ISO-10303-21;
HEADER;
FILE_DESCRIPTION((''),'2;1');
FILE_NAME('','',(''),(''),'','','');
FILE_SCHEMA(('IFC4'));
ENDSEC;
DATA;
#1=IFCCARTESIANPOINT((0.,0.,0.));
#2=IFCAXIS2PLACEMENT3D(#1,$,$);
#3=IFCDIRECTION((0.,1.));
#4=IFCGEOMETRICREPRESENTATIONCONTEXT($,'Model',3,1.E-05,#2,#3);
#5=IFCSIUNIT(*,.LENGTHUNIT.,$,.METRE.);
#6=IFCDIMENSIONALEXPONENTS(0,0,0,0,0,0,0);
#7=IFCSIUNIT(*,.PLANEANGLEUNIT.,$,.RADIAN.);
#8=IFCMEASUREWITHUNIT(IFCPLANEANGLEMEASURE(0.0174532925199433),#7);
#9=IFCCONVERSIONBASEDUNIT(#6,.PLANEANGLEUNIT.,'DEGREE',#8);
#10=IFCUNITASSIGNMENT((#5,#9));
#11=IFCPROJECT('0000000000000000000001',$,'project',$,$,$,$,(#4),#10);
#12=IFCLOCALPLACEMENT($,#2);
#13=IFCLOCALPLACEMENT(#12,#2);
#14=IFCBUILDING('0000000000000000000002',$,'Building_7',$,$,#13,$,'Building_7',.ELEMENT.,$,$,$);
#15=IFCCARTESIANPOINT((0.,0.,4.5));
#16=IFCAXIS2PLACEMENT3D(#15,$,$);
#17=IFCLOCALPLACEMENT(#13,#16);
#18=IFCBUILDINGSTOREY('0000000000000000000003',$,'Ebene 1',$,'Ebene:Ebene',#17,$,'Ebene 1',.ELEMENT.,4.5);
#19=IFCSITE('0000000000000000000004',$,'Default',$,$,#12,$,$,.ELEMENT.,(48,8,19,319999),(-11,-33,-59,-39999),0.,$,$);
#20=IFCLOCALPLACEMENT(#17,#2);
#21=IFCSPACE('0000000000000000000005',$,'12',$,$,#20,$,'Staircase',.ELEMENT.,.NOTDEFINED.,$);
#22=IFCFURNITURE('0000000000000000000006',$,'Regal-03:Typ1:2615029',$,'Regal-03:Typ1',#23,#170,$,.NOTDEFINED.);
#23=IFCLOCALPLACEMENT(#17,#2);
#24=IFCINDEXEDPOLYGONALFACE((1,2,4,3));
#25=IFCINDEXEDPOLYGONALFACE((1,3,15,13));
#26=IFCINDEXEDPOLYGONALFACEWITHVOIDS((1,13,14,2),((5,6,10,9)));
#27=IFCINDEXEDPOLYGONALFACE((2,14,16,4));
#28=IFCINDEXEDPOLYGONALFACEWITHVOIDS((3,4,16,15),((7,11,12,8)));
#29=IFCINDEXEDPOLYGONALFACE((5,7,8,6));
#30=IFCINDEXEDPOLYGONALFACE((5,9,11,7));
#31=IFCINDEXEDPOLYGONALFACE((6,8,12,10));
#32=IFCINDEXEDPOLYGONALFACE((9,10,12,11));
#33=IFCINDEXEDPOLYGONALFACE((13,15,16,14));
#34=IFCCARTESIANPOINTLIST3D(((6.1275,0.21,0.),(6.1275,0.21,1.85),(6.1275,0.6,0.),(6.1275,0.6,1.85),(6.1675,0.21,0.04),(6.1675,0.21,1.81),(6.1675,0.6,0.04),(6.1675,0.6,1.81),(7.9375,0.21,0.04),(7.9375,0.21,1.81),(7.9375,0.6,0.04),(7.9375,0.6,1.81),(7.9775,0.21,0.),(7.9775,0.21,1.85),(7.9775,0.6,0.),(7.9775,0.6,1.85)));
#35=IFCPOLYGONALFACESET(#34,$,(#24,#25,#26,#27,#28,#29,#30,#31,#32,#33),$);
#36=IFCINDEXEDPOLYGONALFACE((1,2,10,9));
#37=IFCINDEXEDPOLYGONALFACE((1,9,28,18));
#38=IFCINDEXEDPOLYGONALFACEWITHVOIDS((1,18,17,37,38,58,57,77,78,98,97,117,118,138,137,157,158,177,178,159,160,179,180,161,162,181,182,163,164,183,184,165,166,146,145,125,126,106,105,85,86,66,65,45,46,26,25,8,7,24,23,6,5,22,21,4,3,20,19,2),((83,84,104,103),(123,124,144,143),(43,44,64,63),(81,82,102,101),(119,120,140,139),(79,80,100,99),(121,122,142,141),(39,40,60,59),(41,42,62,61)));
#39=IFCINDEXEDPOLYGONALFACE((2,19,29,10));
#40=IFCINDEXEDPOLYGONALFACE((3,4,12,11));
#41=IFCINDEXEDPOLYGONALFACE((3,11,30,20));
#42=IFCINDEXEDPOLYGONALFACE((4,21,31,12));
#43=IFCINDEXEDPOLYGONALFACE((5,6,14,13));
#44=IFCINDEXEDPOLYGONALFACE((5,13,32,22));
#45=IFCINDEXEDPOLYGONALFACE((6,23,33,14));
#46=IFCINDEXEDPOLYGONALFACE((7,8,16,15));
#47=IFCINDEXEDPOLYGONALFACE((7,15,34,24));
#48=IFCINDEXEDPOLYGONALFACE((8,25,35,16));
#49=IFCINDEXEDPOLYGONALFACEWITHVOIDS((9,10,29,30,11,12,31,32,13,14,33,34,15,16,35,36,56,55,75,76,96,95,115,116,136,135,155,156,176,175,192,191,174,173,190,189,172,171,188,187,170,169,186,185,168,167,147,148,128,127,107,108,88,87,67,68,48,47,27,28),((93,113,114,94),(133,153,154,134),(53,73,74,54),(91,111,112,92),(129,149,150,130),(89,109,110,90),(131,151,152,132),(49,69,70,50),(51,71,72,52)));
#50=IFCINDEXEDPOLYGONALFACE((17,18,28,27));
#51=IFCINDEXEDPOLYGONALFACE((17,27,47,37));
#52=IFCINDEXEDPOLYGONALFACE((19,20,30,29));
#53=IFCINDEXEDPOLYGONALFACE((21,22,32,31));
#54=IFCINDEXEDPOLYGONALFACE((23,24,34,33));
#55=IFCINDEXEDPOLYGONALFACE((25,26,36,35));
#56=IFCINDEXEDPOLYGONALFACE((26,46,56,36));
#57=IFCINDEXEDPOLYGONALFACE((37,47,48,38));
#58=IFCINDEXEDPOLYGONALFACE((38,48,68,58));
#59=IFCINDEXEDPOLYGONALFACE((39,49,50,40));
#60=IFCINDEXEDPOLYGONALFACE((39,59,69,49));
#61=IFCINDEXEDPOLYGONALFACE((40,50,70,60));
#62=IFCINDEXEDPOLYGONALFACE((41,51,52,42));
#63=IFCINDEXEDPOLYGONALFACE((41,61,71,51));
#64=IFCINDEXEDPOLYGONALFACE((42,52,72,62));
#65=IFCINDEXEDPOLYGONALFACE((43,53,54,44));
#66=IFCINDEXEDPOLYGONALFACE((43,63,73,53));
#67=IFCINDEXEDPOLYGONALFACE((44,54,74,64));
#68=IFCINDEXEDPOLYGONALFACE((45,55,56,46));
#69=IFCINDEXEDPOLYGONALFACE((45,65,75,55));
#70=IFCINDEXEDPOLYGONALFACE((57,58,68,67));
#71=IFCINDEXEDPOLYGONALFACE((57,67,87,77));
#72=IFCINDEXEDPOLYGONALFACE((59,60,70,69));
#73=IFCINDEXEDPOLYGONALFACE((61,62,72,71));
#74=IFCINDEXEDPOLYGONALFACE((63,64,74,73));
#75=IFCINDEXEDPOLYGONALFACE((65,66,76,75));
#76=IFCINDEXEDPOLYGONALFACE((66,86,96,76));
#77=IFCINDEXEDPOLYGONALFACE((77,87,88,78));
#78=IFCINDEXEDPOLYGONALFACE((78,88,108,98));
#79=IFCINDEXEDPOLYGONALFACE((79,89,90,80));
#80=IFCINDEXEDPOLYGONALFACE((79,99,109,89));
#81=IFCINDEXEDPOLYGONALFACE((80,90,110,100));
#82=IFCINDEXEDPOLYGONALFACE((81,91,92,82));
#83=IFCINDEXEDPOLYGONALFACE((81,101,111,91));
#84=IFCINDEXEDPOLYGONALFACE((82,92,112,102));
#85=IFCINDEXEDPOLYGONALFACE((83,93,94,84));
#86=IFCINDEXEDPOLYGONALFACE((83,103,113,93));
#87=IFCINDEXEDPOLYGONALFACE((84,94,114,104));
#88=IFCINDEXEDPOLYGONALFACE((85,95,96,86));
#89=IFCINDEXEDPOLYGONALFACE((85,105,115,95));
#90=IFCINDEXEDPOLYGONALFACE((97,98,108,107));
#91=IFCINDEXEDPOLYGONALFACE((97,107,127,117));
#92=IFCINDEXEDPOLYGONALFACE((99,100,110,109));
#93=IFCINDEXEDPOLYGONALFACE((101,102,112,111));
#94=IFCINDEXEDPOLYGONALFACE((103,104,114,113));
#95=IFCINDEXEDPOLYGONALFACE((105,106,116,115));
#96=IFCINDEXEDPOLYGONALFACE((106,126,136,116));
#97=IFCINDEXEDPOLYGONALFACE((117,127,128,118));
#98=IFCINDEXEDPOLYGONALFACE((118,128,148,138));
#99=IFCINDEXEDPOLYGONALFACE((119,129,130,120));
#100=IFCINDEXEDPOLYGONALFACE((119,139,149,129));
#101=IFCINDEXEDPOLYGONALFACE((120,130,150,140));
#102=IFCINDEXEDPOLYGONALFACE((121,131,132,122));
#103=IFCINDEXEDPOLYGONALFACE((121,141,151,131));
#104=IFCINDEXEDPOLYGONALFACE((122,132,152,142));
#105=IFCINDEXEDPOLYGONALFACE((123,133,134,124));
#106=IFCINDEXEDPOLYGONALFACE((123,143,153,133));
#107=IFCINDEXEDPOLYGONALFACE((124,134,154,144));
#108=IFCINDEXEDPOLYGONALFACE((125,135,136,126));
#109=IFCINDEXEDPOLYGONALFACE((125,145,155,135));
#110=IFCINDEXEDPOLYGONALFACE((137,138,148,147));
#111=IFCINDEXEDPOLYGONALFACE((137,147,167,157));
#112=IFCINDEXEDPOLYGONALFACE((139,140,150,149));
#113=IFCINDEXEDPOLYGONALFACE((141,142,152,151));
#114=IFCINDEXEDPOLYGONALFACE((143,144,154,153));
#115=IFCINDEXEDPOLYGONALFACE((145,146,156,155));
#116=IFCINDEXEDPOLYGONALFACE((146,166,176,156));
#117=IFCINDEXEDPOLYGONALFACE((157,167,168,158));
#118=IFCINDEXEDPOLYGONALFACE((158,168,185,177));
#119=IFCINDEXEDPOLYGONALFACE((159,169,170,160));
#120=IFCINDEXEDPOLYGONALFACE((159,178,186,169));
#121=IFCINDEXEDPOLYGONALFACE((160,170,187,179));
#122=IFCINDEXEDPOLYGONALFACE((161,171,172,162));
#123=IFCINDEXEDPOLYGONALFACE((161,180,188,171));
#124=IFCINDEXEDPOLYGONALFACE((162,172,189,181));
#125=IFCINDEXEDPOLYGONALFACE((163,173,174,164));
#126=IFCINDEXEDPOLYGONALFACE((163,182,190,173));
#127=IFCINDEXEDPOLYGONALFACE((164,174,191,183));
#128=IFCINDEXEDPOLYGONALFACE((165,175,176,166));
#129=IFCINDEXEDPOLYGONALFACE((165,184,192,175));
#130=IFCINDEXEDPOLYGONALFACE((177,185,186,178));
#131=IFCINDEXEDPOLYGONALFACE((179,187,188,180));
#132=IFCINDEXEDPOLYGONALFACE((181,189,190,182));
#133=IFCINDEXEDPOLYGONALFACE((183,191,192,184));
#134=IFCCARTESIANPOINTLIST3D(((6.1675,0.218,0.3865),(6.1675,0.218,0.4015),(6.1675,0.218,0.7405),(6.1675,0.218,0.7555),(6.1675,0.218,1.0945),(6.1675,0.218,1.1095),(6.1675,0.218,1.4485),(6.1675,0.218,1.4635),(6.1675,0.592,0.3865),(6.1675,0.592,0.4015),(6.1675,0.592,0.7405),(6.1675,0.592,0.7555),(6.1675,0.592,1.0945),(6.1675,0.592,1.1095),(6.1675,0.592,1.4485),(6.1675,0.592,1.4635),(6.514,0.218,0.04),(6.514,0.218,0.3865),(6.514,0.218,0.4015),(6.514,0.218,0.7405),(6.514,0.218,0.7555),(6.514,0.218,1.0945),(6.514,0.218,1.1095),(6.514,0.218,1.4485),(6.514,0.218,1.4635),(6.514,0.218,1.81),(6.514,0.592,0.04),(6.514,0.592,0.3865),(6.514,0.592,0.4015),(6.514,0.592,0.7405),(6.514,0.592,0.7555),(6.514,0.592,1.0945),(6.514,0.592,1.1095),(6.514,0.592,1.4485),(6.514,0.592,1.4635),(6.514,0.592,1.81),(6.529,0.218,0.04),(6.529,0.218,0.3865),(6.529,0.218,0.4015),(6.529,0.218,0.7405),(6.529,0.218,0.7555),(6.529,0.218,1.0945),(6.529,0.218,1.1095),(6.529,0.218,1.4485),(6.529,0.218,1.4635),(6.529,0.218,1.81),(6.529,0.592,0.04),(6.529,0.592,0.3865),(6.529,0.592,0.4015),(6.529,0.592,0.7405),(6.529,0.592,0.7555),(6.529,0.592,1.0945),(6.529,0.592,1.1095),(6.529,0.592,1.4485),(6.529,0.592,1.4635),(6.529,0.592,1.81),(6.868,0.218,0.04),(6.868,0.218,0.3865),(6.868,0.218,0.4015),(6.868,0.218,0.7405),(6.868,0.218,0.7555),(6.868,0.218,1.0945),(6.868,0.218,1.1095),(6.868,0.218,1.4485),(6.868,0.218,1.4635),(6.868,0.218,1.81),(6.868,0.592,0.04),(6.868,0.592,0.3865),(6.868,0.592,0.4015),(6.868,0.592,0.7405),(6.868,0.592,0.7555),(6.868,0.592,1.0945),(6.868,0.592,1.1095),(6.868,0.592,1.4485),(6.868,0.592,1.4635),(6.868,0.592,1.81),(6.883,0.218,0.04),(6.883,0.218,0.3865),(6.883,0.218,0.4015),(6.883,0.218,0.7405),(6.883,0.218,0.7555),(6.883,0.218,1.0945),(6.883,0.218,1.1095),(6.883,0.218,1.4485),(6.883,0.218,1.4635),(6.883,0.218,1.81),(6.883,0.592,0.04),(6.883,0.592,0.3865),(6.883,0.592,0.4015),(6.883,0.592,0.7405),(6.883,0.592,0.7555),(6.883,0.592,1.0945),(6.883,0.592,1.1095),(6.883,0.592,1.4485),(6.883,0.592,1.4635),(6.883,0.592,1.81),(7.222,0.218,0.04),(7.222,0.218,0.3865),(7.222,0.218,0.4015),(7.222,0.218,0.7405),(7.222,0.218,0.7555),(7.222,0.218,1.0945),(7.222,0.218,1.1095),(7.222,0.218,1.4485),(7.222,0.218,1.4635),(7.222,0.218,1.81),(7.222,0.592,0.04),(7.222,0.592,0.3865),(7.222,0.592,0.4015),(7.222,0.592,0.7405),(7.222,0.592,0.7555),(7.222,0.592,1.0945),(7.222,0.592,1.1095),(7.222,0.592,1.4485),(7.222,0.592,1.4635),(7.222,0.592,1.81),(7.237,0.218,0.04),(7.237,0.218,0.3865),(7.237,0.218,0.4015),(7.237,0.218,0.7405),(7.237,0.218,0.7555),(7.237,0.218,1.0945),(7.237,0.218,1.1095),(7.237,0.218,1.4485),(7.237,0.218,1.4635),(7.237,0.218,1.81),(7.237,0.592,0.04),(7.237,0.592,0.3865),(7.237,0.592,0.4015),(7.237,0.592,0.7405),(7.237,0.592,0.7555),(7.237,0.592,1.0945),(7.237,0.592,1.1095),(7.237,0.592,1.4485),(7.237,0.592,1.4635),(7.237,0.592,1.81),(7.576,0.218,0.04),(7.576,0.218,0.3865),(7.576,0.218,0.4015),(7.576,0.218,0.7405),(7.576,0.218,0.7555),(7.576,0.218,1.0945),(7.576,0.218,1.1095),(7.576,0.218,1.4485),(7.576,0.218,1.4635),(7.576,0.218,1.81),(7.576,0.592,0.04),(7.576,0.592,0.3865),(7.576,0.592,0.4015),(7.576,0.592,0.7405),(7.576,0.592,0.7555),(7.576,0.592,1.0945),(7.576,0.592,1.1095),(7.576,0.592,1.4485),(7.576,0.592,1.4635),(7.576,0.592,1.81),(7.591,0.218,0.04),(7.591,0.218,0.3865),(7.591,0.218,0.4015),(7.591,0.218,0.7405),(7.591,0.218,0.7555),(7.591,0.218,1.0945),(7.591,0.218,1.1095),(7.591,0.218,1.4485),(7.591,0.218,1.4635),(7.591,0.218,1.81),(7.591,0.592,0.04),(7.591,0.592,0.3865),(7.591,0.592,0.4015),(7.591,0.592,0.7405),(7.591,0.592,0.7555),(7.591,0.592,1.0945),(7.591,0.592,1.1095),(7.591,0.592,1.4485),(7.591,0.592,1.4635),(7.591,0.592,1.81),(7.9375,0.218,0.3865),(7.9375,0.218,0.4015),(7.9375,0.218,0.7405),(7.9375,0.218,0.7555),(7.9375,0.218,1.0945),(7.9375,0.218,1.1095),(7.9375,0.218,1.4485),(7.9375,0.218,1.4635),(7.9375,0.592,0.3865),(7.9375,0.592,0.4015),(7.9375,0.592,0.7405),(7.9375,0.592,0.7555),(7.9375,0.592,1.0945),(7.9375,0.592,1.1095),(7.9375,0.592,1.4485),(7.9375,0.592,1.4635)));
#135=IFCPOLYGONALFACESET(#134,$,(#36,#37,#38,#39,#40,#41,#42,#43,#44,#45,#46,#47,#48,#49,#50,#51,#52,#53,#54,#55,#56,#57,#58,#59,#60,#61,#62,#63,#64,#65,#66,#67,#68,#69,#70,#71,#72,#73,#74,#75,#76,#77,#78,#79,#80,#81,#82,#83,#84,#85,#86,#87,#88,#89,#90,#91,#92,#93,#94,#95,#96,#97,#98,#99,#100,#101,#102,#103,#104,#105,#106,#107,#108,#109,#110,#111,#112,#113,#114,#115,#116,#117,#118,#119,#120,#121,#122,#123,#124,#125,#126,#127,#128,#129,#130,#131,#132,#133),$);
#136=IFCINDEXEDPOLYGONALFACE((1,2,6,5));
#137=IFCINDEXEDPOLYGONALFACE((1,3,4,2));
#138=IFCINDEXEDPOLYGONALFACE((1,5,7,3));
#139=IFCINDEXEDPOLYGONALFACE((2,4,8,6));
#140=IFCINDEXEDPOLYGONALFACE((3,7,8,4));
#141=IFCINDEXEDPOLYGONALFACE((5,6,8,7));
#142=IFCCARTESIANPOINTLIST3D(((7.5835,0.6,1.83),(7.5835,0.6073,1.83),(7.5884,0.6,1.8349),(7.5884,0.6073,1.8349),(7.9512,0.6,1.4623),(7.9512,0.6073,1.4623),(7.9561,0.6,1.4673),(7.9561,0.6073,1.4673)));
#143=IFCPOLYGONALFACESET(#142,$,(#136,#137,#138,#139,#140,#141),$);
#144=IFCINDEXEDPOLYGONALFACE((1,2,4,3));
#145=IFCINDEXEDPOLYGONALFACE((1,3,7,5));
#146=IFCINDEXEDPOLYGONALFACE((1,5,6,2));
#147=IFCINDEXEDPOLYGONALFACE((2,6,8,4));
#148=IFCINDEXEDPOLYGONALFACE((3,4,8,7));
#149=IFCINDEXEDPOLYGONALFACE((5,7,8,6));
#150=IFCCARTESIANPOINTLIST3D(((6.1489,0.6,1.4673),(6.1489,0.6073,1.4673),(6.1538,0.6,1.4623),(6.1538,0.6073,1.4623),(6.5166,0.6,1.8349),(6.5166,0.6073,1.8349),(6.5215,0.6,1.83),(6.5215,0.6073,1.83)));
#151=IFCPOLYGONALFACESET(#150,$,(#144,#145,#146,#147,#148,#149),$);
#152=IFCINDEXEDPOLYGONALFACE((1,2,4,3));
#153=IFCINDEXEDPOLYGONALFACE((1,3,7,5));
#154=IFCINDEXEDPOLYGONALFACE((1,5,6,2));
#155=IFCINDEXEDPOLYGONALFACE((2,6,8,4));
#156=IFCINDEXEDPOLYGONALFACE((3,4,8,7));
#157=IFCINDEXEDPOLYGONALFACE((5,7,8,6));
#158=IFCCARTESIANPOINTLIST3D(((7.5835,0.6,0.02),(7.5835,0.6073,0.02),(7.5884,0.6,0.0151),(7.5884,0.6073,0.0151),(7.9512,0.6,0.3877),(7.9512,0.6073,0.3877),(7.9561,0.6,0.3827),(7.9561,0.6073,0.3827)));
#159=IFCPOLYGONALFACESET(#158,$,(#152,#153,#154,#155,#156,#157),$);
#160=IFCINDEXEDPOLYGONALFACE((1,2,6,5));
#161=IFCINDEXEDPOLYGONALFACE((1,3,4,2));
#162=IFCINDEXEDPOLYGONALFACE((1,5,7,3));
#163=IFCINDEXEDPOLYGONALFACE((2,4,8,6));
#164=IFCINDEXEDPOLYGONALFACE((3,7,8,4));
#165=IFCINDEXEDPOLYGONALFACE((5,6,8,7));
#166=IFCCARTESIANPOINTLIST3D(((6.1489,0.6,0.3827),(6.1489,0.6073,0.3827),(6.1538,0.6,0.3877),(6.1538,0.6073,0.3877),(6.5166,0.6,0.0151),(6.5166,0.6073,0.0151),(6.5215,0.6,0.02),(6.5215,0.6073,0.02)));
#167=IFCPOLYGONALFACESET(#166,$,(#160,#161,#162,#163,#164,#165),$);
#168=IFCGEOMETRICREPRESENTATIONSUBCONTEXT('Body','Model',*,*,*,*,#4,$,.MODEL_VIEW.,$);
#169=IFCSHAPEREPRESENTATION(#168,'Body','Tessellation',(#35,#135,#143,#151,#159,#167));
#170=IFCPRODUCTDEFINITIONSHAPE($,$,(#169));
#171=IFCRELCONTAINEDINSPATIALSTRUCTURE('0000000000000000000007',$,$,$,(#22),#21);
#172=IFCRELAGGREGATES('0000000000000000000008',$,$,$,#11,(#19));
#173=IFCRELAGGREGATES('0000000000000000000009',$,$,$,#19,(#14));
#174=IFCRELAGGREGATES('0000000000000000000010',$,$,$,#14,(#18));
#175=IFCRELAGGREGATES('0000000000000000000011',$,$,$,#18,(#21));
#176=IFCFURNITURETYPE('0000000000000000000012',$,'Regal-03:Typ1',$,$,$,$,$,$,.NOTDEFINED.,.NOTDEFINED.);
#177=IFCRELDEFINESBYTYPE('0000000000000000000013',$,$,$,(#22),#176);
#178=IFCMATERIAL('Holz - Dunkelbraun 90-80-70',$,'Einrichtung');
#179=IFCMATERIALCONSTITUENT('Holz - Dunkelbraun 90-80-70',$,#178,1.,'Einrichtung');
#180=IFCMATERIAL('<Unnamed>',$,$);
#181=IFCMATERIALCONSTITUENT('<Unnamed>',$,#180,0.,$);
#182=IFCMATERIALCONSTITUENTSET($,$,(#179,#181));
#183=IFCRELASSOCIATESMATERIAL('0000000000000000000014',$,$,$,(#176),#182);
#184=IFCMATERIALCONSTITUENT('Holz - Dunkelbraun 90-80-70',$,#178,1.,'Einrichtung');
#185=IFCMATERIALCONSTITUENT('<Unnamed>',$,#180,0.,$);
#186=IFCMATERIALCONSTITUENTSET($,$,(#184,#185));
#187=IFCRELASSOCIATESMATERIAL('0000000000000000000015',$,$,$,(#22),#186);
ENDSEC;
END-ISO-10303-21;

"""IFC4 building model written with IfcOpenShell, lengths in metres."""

from ifc_helpers import new_model, entity, si_unit, converted_unit, direction, frame, origin, place, context, subcontext, project, spatial, indexed_curve, outline, extrude, source, transform, mapped, material, constituent, constituent_set, type_object, type_shapes, element, save


model = new_model("IFC4")

# Units and contexts
model_context = context("Model", 3, precision=1e-05, world=origin(), true_north=direction((0.0, 1.0)))
body_context = subcontext(model_context, "Body", "Model", "MODEL_VIEW")
ifc_project = project(units=[si_unit("LENGTHUNIT", "METRE"), converted_unit("PLANEANGLEUNIT", "DEGREE", entity("IfcPlaneAngleMeasure", 0.0174532925199433), si_unit("PLANEANGLEUNIT", "RADIAN"), dimensions=[0, 0, 0, 0, 0, 0, 0])], contexts=[model_context])

# Site, building, storey
site_placement = place(None, origin())
site = spatial("IfcSite", under=ifc_project, at=site_placement, Name="Default", CompositionType="ELEMENT", RefLatitude=(48, 8, 19, 319999), RefLongitude=(-11, -33, -59, -39999), RefElevation=0.0)
building_placement = place(site_placement, origin())
building = spatial("IfcBuilding", under=site, at=building_placement, Name="Building_7", LongName="Building_7", CompositionType="ELEMENT")
storey_placement = place(building_placement, frame((0.0, 0.0, 4.5)))
storey = spatial("IfcBuildingStorey", under=building, at=storey_placement, Name="Ebene 1", ObjectType="Ebene:Ebene", LongName="Ebene 1", CompositionType="ELEMENT", Elevation=4.5)

# Shared definitions
ifc_material_1 = material(Name="<Unnamed>")

# Shared definitions
ifc_material_2 = material(Name="Holz - Dunkelbraun 90-80-70", Category="Einrichtung")
ifc_constituent_1 = constituent(ifc_material_2, Name="Holz - Dunkelbraun 90-80-70", Category="Einrichtung", fraction=1.0)
ifc_constituent_2 = constituent(ifc_material_1, Name="<Unnamed>", fraction=0.0)
ifc_constituent_set_1 = constituent_set(constituents=[ifc_constituent_1, ifc_constituent_2])
furniture_type_1 = type_object("IfcFurnitureType", Name="Regal-03:Typ1", AssemblyPlace="NOTDEFINED", PredefinedType="NOTDEFINED", material=ifc_constituent_set_1)
shared_shape_1 = source(origin(), body_context, "Body", "SweptSolid", [
    extrude(outline(indexed_curve([(-0.925, -0.925), (0.925, -0.925), (0.925, 0.925), (-0.925, 0.925), (-0.925, -0.925)], self_intersect=False), holes=[indexed_curve([(-0.885, -0.885), (-0.885, 0.885), (0.885, 0.885), (0.885, -0.885), (-0.885, -0.885)], self_intersect=False)]), frame((0.2471, -0.2651, 0.925), z_axis=(0.0, 1.0, 0.0), x_axis=(0.0, 0.0, -1.0)), (0.0, 0.0, 1.0), 0.39),
    extrude(outline(indexed_curve([(0.5385, -0.5385), (0.885, -0.5385), (0.885, -0.5235), (0.5385, -0.5235), (0.5385, -0.1845), (0.885, -0.1845), (0.885, -0.1695), (0.5385, -0.1695), (0.5385, 0.1695), (0.885, 0.1695), (0.885, 0.1845), (0.5385, 0.1845), (0.5385, 0.5235), (0.885, 0.5235), (0.885, 0.5385), (0.5385, 0.5385), (0.5385, 0.885), (0.5235, 0.885), (0.5235, 0.5385), (0.1845, 0.5385), (0.1845, 0.885), (0.1695, 0.885), (0.1695, 0.5385), (-0.1695, 0.5385), (-0.1695, 0.885), (-0.1845, 0.885), (-0.1845, 0.5385), (-0.5235, 0.5385), (-0.5235, 0.885), (-0.5385, 0.885), (-0.5385, 0.5385), (-0.885, 0.5385), (-0.885, 0.5235), (-0.5385, 0.5235), (-0.5385, 0.1845), (-0.885, 0.1845), (-0.885, 0.1695), (-0.5385, 0.1695), (-0.5385, -0.1695), (-0.885, -0.1695), (-0.885, -0.1845), (-0.5385, -0.1845), (-0.5385, -0.5235), (-0.885, -0.5235), (-0.885, -0.5385), (-0.5385, -0.5385), (-0.5385, -0.885), (-0.5235, -0.885), (-0.5235, -0.5385), (-0.1845, -0.5385), (-0.1845, -0.885), (-0.1695, -0.885), (-0.1695, -0.5385), (0.1695, -0.5385), (0.1695, -0.885), (0.1845, -0.885), (0.1845, -0.5385), (0.5235, -0.5385), (0.5235, -0.885), (0.5385, -0.885), (0.5385, -0.5385)], self_intersect=False), holes=[indexed_curve([(0.5235, -0.1845), (0.5235, -0.5235), (0.1845, -0.5235), (0.1845, -0.1845), (0.5235, -0.1845)], self_intersect=False), indexed_curve([(0.1845, -0.1695), (0.1845, 0.1695), (0.5235, 0.1695), (0.5235, -0.1695), (0.1845, -0.1695)], self_intersect=False), indexed_curve([(0.1845, 0.1845), (0.1845, 0.5235), (0.5235, 0.5235), (0.5235, 0.1845), (0.1845, 0.1845)], self_intersect=False), indexed_curve([(-0.1695, 0.5235), (0.1695, 0.5235), (0.1695, 0.1845), (-0.1695, 0.1845), (-0.1695, 0.5235)], self_intersect=False), indexed_curve([(-0.1695, 0.1695), (0.1695, 0.1695), (0.1695, -0.1695), (-0.1695, -0.1695), (-0.1695, 0.1695)], self_intersect=False), indexed_curve([(-0.1695, -0.1845), (0.1695, -0.1845), (0.1695, -0.5235), (-0.1695, -0.5235), (-0.1695, -0.1845)], self_intersect=False), indexed_curve([(-0.5235, -0.5235), (-0.5235, -0.1845), (-0.1845, -0.1845), (-0.1845, -0.5235), (-0.5235, -0.5235)], self_intersect=False), indexed_curve([(-0.5235, -0.1695), (-0.5235, 0.1695), (-0.1845, 0.1695), (-0.1845, -0.1695), (-0.5235, -0.1695)], self_intersect=False), indexed_curve([(-0.5235, 0.1845), (-0.5235, 0.5235), (-0.1845, 0.5235), (-0.1845, 0.1845), (-0.5235, 0.1845)], self_intersect=False)]), frame((0.2471, -0.2571, 0.925), z_axis=(0.0, 1.0, 0.0), x_axis=(0.0, 0.0, 1.0)), (0.0, 0.0, 1.0), 0.374),
    extrude(outline(indexed_curve([(-0.0037, -0.0035), (0.0037, -0.0035), (0.0037, 0.0035), (-0.0037, 0.0035), (-0.0037, -0.0035)], self_intersect=False)), frame((1.1482, 0.1286, 1.4648), z_axis=(-0.707107, 0.0, 0.707107), x_axis=(0.0, 1.0, 0.0)), (0.0, 0.0, 1.0), 0.52),
    extrude(outline(indexed_curve([(-0.0037, -0.0035), (0.0037, -0.0035), (0.0037, 0.0035), (-0.0037, 0.0035), (-0.0037, -0.0035)], self_intersect=False)), frame((-0.6541, 0.1286, 1.4648), z_axis=(0.707107, 0.0, 0.707107), x_axis=(0.0, 1.0, 0.0)), (0.0, 0.0, 1.0), 0.52),
    extrude(outline(indexed_curve([(-0.0037, -0.0035), (0.0037, -0.0035), (0.0037, 0.0035), (-0.0037, 0.0035), (-0.0037, -0.0035)], self_intersect=False)), frame((0.7805, 0.1286, 0.0175), z_axis=(0.707107, 0.0, 0.707107), x_axis=(0.0, 1.0, 0.0)), (0.0, 0.0, 1.0), 0.52),
    extrude(outline(indexed_curve([(-0.0037, -0.0035), (0.0037, -0.0035), (0.0037, 0.0035), (-0.0037, 0.0035), (-0.0037, -0.0035)], self_intersect=False)), frame((-0.2864, 0.1286, 0.0175), z_axis=(-0.707107, 0.0, 0.707107), x_axis=(0.0, 1.0, 0.0)), (0.0, 0.0, 1.0), 0.52),
])
type_shapes(furniture_type_1, [shared_shape_1])

# Shared definitions
space_1_placement = place(storey_placement, origin())
space_1 = spatial("IfcSpace", under=storey, at=space_1_placement, Name="12", LongName="Staircase", CompositionType="ELEMENT", PredefinedType="NOTDEFINED")

# Furniture
ifc_constituent_3 = constituent(ifc_material_2, Name="Holz - Dunkelbraun 90-80-70", Category="Einrichtung", fraction=1.0)
ifc_constituent_4 = constituent(ifc_material_1, Name="<Unnamed>", fraction=0.0)
ifc_constituent_set_2 = constituent_set(constituents=[ifc_constituent_3, ifc_constituent_4])
furniture_1_placement = place(space_1_placement, frame((6.8054, 0.4751, 0.0)))
element("IfcFurniture", 1, at=furniture_1_placement, inside=space_1, type_object=furniture_type_1, material=ifc_constituent_set_2, Name="Regal-03:Typ1:2615029", ObjectType="Regal-03:Typ1", PredefinedType="NOTDEFINED", context=body_context, shape_type="MappedRepresentation", body=[
    mapped(shared_shape_1, transform((0.0, 0.0, 0.0), scale=1.0)),
])

save(model, "model.ifc")
